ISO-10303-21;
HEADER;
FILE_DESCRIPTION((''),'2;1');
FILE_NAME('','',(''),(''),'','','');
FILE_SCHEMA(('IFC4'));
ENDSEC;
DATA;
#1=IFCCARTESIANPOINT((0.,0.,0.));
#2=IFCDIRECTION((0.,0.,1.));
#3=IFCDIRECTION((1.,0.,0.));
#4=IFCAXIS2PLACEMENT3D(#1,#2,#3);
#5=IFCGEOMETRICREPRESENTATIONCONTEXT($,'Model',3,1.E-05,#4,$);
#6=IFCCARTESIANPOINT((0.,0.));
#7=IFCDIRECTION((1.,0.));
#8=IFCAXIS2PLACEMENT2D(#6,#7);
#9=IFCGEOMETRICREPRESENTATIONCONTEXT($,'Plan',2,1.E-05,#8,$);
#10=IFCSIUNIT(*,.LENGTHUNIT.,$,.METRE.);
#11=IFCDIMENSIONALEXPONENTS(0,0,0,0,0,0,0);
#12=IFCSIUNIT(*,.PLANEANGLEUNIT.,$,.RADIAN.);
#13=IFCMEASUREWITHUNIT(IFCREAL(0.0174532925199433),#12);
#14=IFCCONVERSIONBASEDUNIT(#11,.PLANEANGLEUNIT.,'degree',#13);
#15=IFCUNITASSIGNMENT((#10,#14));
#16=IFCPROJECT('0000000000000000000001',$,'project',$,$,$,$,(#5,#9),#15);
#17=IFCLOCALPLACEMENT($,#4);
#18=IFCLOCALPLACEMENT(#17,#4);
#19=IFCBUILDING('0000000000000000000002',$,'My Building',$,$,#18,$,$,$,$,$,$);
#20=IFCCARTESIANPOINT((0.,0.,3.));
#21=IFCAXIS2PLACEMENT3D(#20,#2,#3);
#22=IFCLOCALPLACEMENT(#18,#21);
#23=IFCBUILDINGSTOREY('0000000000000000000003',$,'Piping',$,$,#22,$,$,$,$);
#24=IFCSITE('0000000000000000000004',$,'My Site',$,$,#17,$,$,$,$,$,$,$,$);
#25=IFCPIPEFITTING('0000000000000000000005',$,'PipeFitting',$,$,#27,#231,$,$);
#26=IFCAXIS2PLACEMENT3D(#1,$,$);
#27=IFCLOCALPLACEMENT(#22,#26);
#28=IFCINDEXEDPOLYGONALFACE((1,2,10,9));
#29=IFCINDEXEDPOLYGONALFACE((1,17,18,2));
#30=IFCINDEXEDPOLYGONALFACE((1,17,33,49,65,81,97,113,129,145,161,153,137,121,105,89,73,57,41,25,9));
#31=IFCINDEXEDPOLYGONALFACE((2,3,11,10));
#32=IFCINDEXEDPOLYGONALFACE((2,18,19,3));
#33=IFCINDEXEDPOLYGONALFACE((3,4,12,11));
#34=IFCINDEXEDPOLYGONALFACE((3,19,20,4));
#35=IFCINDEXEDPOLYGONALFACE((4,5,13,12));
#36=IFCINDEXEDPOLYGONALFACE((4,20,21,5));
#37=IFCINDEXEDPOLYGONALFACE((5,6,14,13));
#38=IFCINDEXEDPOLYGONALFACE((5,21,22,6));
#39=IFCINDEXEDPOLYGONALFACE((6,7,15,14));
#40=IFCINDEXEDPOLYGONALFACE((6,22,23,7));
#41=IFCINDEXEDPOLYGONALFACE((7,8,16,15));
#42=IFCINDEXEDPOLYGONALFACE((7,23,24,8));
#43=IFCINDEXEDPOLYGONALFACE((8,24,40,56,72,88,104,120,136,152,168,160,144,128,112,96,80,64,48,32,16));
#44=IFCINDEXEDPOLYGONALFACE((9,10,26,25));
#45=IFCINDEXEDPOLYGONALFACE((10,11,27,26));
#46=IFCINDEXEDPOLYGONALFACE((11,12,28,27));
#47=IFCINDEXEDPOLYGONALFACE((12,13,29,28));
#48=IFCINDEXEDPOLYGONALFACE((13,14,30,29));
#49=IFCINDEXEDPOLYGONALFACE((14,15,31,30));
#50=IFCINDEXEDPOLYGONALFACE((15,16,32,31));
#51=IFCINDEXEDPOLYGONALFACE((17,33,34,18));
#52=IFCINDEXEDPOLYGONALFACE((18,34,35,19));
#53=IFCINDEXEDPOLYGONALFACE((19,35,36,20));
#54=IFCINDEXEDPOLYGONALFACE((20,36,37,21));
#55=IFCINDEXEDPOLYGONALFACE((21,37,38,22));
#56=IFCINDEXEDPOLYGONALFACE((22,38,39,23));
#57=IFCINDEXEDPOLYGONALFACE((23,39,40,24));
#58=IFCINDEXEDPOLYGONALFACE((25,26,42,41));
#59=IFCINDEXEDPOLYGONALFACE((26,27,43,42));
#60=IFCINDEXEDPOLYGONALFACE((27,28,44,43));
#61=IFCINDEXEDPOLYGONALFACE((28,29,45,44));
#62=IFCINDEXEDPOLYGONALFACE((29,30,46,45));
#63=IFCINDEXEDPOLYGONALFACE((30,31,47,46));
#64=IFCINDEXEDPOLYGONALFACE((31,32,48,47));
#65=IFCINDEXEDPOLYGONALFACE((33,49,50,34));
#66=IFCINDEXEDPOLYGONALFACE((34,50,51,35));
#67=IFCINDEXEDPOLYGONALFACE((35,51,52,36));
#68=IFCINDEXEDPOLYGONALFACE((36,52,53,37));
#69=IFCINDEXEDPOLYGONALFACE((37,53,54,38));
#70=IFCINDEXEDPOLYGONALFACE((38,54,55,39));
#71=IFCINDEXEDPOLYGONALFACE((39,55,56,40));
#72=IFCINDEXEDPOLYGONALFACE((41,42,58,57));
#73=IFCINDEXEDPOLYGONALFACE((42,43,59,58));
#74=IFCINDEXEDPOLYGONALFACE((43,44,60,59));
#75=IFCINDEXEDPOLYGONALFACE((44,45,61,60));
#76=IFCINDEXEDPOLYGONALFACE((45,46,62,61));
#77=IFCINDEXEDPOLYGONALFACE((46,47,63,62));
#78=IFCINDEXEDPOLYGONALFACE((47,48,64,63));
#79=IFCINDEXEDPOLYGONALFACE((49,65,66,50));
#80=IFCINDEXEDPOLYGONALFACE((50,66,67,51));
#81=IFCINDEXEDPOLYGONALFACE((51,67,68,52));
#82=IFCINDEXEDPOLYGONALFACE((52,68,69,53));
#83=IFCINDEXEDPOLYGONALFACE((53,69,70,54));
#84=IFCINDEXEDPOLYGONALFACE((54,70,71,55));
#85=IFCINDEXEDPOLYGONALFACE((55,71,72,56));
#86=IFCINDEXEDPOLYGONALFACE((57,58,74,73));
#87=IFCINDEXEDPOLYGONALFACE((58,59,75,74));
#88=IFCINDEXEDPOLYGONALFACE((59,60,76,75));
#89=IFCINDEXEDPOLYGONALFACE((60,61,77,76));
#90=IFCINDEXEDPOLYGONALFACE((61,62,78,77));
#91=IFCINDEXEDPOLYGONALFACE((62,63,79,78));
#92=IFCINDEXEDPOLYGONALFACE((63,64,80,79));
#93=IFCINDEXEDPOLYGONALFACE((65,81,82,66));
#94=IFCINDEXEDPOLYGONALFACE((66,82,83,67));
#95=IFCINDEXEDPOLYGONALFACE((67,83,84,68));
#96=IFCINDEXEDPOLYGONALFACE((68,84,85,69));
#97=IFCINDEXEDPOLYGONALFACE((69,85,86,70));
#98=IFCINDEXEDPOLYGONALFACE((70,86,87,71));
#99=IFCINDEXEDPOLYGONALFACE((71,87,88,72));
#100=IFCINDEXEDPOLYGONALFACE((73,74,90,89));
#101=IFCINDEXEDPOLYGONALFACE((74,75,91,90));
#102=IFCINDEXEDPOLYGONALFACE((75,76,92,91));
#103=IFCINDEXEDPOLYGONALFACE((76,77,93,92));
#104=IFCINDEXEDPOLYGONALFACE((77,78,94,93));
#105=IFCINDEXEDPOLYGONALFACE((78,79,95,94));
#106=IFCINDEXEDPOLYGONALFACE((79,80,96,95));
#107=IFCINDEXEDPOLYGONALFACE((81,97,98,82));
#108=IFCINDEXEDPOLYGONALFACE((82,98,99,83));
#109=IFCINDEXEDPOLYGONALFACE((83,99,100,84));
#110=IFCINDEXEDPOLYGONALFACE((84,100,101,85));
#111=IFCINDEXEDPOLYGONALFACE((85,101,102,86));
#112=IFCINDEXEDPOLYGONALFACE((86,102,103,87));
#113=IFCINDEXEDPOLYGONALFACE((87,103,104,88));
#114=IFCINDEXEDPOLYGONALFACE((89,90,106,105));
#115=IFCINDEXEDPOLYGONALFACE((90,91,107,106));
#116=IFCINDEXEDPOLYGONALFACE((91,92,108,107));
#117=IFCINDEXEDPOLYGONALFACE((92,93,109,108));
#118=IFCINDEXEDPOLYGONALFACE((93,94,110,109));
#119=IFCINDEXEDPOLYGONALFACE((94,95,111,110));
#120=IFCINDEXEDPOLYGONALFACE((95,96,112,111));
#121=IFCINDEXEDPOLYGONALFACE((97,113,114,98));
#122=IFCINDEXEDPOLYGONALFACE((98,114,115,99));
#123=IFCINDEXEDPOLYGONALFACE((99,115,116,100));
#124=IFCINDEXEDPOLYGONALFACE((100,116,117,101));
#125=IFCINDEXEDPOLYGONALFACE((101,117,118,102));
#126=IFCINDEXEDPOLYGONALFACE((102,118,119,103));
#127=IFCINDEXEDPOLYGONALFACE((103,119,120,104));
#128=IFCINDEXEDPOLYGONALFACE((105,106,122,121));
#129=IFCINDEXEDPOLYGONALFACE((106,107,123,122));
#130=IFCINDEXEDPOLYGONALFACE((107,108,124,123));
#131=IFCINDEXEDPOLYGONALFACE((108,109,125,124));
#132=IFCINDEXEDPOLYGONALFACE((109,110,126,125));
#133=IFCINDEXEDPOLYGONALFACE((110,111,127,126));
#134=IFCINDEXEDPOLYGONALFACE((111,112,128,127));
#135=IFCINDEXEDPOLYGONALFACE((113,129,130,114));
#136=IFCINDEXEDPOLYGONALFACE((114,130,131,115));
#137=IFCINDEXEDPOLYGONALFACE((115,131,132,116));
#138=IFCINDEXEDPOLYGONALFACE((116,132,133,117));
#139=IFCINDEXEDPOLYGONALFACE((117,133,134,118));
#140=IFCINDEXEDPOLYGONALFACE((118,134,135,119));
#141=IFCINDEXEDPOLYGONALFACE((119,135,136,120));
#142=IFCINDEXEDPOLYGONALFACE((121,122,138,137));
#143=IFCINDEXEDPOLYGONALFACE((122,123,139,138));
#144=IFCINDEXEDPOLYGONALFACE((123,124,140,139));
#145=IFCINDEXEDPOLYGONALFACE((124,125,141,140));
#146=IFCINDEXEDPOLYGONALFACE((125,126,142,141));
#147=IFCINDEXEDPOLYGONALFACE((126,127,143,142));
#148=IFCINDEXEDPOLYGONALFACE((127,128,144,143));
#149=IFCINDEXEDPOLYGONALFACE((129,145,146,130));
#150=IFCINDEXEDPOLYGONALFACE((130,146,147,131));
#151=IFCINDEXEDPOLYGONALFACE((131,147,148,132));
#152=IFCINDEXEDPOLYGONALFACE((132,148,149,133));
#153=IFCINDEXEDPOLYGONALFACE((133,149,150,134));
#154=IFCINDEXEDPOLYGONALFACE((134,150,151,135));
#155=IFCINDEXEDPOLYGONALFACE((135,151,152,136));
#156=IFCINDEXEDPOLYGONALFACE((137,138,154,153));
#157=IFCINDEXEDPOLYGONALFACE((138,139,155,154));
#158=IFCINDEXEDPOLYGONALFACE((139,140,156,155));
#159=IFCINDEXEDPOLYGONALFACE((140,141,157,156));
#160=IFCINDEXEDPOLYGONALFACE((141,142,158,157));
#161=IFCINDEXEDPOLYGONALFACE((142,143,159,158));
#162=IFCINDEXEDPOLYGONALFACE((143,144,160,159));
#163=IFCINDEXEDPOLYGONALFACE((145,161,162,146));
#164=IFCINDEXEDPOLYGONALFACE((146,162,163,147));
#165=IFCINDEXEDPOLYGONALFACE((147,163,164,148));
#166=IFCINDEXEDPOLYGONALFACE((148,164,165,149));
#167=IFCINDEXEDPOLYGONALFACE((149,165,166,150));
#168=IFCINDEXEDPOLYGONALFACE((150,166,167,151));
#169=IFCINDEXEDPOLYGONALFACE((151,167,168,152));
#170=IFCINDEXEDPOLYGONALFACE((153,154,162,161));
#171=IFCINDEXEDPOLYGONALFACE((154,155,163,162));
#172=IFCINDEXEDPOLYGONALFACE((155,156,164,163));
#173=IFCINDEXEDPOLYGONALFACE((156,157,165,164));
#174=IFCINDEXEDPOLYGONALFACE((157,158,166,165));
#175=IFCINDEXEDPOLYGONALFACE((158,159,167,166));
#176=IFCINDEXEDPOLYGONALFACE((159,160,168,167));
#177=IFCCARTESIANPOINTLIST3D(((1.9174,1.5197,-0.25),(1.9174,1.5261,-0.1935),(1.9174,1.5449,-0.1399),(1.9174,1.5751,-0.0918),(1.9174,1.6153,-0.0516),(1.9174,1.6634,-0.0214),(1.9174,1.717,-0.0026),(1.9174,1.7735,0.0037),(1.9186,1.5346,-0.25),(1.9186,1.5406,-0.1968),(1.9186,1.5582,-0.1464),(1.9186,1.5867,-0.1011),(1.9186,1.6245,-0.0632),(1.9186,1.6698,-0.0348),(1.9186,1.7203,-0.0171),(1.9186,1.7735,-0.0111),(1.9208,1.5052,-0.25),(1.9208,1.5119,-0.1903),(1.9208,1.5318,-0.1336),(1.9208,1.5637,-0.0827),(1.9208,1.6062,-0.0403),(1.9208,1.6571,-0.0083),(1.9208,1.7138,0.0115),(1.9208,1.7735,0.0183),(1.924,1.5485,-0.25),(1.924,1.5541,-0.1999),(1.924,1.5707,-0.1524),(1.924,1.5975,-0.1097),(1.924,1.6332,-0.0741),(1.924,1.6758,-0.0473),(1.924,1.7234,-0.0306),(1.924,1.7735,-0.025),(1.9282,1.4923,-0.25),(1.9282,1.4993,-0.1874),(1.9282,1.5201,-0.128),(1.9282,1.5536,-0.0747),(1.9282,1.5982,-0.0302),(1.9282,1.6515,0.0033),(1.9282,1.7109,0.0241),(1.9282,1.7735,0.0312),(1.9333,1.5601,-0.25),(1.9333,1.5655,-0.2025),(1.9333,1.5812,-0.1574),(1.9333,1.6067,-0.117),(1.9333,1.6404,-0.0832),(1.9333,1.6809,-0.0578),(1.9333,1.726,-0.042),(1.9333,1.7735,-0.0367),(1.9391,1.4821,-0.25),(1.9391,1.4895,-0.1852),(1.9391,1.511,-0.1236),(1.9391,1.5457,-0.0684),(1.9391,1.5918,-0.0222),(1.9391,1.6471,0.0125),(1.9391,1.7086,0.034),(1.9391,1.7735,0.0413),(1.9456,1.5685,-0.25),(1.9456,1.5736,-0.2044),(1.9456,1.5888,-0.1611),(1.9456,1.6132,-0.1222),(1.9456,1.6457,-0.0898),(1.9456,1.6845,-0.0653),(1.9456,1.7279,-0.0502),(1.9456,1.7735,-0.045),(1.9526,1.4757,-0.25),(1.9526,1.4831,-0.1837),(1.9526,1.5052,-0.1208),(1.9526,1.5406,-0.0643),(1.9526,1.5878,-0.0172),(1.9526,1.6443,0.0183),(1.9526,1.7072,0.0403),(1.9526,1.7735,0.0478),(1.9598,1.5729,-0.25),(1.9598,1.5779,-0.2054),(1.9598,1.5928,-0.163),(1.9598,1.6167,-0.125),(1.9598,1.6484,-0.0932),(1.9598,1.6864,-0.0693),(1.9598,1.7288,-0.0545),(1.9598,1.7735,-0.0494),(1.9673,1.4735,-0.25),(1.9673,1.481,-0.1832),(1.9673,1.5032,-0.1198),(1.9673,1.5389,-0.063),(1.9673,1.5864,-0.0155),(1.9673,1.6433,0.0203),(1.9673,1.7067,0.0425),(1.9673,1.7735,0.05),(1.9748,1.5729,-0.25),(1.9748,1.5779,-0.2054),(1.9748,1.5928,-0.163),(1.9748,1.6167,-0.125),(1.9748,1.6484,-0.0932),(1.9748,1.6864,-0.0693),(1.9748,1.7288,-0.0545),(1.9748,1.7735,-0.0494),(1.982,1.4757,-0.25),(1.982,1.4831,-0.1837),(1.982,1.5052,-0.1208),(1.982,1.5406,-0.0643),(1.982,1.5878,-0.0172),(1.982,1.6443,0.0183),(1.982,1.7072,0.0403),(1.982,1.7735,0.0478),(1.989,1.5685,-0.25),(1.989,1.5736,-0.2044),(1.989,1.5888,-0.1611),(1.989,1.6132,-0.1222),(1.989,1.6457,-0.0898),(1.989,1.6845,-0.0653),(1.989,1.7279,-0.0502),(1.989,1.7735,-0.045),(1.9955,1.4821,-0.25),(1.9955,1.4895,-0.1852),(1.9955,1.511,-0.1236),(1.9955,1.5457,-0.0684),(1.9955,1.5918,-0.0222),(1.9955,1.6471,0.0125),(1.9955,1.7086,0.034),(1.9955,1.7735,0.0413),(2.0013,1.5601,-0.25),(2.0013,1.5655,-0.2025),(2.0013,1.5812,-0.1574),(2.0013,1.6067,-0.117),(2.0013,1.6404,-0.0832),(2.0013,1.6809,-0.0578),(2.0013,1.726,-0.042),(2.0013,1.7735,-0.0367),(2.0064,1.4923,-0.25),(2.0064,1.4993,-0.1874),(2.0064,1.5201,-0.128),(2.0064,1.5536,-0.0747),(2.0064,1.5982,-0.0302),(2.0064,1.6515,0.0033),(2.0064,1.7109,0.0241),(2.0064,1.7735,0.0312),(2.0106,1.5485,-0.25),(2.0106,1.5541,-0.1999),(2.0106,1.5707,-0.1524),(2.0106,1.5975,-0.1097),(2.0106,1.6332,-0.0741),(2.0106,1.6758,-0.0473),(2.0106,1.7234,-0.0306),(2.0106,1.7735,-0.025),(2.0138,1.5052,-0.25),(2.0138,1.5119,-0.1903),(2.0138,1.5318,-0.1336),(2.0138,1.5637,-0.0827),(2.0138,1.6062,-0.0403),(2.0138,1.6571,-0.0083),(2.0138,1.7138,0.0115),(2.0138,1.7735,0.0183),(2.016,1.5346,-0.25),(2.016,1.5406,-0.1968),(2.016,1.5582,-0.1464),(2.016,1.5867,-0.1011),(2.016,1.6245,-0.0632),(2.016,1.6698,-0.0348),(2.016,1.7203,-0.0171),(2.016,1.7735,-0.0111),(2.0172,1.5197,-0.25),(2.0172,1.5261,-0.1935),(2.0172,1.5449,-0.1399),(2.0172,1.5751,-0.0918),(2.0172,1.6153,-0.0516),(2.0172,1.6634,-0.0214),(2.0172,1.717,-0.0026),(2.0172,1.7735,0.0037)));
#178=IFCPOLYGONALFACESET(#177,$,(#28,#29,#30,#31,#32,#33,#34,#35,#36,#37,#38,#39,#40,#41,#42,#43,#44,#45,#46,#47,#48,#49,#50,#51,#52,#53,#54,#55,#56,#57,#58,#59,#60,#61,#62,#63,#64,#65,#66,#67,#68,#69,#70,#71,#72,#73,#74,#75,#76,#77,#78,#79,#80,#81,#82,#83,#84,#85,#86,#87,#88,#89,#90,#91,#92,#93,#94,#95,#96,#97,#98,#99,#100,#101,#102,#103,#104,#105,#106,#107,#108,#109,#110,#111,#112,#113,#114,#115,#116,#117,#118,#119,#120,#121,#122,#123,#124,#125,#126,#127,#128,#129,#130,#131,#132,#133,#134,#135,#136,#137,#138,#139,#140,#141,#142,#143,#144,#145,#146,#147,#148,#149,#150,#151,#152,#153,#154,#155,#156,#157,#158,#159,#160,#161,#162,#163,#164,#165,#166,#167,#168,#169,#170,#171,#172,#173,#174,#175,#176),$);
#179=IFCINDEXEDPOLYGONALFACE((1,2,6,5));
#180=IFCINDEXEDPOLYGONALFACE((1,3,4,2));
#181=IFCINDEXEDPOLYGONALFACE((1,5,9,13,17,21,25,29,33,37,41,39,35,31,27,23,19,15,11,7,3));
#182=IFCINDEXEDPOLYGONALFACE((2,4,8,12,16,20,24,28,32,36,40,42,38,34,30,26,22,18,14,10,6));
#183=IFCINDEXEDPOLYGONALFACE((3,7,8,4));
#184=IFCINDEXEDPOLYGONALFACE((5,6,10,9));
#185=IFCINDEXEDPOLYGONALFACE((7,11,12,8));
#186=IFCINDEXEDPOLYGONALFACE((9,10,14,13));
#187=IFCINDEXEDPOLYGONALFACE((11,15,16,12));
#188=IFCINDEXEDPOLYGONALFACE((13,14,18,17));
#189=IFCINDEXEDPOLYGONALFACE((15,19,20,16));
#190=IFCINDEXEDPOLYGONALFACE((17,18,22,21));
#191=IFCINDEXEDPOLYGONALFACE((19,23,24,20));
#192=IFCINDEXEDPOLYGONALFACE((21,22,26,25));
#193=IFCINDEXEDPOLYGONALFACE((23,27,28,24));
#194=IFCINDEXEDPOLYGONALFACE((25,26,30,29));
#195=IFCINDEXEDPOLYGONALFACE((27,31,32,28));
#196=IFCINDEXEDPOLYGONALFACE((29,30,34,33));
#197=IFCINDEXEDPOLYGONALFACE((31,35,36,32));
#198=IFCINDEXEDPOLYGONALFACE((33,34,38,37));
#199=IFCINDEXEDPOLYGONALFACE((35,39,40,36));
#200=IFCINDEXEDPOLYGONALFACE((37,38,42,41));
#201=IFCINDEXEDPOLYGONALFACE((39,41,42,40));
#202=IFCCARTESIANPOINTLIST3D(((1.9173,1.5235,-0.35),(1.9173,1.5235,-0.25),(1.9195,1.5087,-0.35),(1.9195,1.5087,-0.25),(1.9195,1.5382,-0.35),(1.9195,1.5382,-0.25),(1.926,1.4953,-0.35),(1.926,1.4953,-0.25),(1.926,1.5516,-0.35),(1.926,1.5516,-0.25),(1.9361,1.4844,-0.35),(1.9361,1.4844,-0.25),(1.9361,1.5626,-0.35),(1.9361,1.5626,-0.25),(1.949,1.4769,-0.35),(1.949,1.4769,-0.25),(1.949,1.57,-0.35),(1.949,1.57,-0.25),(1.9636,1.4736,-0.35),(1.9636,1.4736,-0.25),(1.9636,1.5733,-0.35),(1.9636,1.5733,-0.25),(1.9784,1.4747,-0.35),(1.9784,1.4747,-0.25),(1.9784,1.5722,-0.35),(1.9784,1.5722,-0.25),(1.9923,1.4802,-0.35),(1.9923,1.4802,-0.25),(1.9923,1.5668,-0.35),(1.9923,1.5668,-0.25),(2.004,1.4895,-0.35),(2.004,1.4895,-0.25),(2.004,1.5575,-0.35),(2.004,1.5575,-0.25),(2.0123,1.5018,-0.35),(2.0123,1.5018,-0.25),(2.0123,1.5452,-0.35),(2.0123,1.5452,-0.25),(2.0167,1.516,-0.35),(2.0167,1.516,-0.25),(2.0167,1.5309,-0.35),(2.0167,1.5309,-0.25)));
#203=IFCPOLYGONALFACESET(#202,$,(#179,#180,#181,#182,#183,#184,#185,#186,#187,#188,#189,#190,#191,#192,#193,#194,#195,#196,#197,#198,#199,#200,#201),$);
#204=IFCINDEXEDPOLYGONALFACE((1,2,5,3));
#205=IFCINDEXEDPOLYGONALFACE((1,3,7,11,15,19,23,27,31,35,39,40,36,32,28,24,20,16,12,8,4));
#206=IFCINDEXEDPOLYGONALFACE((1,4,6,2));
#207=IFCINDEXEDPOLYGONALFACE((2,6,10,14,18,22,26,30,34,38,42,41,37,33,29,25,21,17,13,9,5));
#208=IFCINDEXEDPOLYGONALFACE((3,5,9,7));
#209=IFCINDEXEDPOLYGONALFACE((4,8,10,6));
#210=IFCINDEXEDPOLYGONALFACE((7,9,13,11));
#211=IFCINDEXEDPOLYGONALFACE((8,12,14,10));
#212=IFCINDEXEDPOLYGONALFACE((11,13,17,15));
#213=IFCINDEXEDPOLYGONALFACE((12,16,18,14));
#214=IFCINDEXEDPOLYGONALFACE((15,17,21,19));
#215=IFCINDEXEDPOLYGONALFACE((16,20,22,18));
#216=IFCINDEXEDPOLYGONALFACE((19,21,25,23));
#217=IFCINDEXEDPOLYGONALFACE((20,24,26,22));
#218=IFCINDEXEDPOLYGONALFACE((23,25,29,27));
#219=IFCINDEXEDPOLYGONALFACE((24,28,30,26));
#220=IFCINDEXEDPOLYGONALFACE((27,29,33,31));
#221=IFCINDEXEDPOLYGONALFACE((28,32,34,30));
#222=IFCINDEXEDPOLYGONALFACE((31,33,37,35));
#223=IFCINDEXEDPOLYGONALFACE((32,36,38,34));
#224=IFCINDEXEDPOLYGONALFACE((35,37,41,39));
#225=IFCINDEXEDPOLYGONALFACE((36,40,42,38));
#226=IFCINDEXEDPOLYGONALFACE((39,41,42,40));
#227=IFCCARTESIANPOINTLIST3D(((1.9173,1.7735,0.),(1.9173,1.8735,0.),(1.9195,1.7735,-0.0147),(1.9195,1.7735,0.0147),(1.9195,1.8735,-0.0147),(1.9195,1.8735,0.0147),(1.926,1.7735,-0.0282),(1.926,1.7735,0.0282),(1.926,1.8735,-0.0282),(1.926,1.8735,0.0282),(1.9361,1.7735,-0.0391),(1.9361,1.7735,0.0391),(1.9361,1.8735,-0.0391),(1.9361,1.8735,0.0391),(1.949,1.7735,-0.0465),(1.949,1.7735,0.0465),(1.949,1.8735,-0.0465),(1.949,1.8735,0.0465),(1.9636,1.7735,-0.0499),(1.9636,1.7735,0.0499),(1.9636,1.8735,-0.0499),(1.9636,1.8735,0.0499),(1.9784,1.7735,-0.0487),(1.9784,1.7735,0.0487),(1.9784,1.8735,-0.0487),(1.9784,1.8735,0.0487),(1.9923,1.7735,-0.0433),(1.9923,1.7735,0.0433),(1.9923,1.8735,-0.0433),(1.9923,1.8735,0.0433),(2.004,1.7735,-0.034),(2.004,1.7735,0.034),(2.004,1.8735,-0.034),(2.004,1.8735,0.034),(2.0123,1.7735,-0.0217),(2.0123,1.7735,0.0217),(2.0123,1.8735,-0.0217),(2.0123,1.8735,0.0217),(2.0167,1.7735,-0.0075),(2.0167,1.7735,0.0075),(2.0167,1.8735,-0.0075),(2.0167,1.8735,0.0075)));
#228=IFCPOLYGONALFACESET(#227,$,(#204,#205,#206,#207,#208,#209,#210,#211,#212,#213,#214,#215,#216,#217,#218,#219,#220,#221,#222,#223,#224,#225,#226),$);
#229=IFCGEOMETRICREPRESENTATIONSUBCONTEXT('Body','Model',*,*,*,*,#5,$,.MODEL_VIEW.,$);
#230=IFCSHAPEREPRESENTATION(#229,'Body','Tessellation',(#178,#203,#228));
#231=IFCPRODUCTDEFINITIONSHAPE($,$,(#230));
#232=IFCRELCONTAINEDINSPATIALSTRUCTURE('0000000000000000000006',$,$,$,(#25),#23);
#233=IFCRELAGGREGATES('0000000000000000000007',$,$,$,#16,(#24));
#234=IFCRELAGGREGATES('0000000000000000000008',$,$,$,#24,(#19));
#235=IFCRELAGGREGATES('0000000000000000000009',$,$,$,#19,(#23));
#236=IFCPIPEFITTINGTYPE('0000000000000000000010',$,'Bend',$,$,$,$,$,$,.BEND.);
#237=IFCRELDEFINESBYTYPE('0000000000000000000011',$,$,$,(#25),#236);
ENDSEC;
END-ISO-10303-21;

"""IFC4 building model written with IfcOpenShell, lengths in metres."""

from ifc_helpers import new_model, entity, si_unit, converted_unit, frame, origin_with_axes, origin_2d_with_axis, place, context, subcontext, project, spatial, circle, extrude, source, transform, mapped, type_object, type_shapes, element, save


model = new_model("IFC4")

# Units and contexts
model_context = context("Model", 3, precision=1e-05, world=origin_with_axes())
plan_context = context("Plan", 2, precision=1e-05, world=origin_2d_with_axis())
body_context = subcontext(model_context, "Body", "Model", "MODEL_VIEW")
ifc_project = project(units=[si_unit("LENGTHUNIT", "METRE"), converted_unit("PLANEANGLEUNIT", "degree", entity("IfcReal", 0.0174532925199433), si_unit("PLANEANGLEUNIT", "RADIAN"), dimensions=[0, 0, 0, 0, 0, 0, 0])], contexts=[model_context, plan_context])

# Site, building, storey
site_placement = place(None, origin_with_axes())
site = spatial("IfcSite", under=ifc_project, at=site_placement, Name="My Site")
building_placement = place(site_placement, origin_with_axes())
building = spatial("IfcBuilding", under=site, at=building_placement, Name="My Building")
storey_placement = place(building_placement, frame((0.0, 0.0, 3.0), z_axis=(0.0, 0.0, 1.0), x_axis=(1.0, 0.0, 0.0)))
storey = spatial("IfcBuildingStorey", under=building, at=storey_placement, Name="Piping")

# Pipe fitting
pipe_fitting_type = type_object("IfcPipeFittingType", Name="Bend", PredefinedType="BEND")
shared_shape = source(origin_with_axes(), body_context, "Body", "SolidModel", [
    entity("IfcSweptDiskSolid", entity("IfcIndexedPolyCurve", entity("IfcCartesianPointList3D", [[0.0, 0.0, -0.1], [0.0, 0.0732, -0.2768], [0.0, 0.25, -0.35]]), [entity("IfcArcIndex", [1, 2, 3])]), 0.05),
    extrude(circle(Radius=0.05), origin_with_axes(), (0.0, 0.0, -1.0), 0.1),
    extrude(circle(Radius=0.05), frame((0.0, 0.25, -0.35), z_axis=(0.0, 1.0, 0.0), x_axis=(1.0, 0.0, 0.0)), (0.0, 0.0, 1.0), 0.1),
])
type_shapes(pipe_fitting_type, [shared_shape])
pipe_fitting_placement = place(storey_placement, frame((1.9673, 1.5235, -0.35), z_axis=(0.0, 0.0, -1.0), x_axis=(-1.0, 0.0, 0.0)))
element("IfcPipeFitting", 1, at=pipe_fitting_placement, inside=storey, type_object=pipe_fitting_type, Name="PipeFitting", context=body_context, shape_type="MappedRepresentation", body=[
    mapped(shared_shape, transform((0.0, 0.0, 0.0), x_axis=(1.0, 0.0, 0.0), y_axis=(0.0, 1.0, 0.0), z_axis=(0.0, 0.0, 1.0), scale=1.0)),
])

save(model, "model.ifc")
